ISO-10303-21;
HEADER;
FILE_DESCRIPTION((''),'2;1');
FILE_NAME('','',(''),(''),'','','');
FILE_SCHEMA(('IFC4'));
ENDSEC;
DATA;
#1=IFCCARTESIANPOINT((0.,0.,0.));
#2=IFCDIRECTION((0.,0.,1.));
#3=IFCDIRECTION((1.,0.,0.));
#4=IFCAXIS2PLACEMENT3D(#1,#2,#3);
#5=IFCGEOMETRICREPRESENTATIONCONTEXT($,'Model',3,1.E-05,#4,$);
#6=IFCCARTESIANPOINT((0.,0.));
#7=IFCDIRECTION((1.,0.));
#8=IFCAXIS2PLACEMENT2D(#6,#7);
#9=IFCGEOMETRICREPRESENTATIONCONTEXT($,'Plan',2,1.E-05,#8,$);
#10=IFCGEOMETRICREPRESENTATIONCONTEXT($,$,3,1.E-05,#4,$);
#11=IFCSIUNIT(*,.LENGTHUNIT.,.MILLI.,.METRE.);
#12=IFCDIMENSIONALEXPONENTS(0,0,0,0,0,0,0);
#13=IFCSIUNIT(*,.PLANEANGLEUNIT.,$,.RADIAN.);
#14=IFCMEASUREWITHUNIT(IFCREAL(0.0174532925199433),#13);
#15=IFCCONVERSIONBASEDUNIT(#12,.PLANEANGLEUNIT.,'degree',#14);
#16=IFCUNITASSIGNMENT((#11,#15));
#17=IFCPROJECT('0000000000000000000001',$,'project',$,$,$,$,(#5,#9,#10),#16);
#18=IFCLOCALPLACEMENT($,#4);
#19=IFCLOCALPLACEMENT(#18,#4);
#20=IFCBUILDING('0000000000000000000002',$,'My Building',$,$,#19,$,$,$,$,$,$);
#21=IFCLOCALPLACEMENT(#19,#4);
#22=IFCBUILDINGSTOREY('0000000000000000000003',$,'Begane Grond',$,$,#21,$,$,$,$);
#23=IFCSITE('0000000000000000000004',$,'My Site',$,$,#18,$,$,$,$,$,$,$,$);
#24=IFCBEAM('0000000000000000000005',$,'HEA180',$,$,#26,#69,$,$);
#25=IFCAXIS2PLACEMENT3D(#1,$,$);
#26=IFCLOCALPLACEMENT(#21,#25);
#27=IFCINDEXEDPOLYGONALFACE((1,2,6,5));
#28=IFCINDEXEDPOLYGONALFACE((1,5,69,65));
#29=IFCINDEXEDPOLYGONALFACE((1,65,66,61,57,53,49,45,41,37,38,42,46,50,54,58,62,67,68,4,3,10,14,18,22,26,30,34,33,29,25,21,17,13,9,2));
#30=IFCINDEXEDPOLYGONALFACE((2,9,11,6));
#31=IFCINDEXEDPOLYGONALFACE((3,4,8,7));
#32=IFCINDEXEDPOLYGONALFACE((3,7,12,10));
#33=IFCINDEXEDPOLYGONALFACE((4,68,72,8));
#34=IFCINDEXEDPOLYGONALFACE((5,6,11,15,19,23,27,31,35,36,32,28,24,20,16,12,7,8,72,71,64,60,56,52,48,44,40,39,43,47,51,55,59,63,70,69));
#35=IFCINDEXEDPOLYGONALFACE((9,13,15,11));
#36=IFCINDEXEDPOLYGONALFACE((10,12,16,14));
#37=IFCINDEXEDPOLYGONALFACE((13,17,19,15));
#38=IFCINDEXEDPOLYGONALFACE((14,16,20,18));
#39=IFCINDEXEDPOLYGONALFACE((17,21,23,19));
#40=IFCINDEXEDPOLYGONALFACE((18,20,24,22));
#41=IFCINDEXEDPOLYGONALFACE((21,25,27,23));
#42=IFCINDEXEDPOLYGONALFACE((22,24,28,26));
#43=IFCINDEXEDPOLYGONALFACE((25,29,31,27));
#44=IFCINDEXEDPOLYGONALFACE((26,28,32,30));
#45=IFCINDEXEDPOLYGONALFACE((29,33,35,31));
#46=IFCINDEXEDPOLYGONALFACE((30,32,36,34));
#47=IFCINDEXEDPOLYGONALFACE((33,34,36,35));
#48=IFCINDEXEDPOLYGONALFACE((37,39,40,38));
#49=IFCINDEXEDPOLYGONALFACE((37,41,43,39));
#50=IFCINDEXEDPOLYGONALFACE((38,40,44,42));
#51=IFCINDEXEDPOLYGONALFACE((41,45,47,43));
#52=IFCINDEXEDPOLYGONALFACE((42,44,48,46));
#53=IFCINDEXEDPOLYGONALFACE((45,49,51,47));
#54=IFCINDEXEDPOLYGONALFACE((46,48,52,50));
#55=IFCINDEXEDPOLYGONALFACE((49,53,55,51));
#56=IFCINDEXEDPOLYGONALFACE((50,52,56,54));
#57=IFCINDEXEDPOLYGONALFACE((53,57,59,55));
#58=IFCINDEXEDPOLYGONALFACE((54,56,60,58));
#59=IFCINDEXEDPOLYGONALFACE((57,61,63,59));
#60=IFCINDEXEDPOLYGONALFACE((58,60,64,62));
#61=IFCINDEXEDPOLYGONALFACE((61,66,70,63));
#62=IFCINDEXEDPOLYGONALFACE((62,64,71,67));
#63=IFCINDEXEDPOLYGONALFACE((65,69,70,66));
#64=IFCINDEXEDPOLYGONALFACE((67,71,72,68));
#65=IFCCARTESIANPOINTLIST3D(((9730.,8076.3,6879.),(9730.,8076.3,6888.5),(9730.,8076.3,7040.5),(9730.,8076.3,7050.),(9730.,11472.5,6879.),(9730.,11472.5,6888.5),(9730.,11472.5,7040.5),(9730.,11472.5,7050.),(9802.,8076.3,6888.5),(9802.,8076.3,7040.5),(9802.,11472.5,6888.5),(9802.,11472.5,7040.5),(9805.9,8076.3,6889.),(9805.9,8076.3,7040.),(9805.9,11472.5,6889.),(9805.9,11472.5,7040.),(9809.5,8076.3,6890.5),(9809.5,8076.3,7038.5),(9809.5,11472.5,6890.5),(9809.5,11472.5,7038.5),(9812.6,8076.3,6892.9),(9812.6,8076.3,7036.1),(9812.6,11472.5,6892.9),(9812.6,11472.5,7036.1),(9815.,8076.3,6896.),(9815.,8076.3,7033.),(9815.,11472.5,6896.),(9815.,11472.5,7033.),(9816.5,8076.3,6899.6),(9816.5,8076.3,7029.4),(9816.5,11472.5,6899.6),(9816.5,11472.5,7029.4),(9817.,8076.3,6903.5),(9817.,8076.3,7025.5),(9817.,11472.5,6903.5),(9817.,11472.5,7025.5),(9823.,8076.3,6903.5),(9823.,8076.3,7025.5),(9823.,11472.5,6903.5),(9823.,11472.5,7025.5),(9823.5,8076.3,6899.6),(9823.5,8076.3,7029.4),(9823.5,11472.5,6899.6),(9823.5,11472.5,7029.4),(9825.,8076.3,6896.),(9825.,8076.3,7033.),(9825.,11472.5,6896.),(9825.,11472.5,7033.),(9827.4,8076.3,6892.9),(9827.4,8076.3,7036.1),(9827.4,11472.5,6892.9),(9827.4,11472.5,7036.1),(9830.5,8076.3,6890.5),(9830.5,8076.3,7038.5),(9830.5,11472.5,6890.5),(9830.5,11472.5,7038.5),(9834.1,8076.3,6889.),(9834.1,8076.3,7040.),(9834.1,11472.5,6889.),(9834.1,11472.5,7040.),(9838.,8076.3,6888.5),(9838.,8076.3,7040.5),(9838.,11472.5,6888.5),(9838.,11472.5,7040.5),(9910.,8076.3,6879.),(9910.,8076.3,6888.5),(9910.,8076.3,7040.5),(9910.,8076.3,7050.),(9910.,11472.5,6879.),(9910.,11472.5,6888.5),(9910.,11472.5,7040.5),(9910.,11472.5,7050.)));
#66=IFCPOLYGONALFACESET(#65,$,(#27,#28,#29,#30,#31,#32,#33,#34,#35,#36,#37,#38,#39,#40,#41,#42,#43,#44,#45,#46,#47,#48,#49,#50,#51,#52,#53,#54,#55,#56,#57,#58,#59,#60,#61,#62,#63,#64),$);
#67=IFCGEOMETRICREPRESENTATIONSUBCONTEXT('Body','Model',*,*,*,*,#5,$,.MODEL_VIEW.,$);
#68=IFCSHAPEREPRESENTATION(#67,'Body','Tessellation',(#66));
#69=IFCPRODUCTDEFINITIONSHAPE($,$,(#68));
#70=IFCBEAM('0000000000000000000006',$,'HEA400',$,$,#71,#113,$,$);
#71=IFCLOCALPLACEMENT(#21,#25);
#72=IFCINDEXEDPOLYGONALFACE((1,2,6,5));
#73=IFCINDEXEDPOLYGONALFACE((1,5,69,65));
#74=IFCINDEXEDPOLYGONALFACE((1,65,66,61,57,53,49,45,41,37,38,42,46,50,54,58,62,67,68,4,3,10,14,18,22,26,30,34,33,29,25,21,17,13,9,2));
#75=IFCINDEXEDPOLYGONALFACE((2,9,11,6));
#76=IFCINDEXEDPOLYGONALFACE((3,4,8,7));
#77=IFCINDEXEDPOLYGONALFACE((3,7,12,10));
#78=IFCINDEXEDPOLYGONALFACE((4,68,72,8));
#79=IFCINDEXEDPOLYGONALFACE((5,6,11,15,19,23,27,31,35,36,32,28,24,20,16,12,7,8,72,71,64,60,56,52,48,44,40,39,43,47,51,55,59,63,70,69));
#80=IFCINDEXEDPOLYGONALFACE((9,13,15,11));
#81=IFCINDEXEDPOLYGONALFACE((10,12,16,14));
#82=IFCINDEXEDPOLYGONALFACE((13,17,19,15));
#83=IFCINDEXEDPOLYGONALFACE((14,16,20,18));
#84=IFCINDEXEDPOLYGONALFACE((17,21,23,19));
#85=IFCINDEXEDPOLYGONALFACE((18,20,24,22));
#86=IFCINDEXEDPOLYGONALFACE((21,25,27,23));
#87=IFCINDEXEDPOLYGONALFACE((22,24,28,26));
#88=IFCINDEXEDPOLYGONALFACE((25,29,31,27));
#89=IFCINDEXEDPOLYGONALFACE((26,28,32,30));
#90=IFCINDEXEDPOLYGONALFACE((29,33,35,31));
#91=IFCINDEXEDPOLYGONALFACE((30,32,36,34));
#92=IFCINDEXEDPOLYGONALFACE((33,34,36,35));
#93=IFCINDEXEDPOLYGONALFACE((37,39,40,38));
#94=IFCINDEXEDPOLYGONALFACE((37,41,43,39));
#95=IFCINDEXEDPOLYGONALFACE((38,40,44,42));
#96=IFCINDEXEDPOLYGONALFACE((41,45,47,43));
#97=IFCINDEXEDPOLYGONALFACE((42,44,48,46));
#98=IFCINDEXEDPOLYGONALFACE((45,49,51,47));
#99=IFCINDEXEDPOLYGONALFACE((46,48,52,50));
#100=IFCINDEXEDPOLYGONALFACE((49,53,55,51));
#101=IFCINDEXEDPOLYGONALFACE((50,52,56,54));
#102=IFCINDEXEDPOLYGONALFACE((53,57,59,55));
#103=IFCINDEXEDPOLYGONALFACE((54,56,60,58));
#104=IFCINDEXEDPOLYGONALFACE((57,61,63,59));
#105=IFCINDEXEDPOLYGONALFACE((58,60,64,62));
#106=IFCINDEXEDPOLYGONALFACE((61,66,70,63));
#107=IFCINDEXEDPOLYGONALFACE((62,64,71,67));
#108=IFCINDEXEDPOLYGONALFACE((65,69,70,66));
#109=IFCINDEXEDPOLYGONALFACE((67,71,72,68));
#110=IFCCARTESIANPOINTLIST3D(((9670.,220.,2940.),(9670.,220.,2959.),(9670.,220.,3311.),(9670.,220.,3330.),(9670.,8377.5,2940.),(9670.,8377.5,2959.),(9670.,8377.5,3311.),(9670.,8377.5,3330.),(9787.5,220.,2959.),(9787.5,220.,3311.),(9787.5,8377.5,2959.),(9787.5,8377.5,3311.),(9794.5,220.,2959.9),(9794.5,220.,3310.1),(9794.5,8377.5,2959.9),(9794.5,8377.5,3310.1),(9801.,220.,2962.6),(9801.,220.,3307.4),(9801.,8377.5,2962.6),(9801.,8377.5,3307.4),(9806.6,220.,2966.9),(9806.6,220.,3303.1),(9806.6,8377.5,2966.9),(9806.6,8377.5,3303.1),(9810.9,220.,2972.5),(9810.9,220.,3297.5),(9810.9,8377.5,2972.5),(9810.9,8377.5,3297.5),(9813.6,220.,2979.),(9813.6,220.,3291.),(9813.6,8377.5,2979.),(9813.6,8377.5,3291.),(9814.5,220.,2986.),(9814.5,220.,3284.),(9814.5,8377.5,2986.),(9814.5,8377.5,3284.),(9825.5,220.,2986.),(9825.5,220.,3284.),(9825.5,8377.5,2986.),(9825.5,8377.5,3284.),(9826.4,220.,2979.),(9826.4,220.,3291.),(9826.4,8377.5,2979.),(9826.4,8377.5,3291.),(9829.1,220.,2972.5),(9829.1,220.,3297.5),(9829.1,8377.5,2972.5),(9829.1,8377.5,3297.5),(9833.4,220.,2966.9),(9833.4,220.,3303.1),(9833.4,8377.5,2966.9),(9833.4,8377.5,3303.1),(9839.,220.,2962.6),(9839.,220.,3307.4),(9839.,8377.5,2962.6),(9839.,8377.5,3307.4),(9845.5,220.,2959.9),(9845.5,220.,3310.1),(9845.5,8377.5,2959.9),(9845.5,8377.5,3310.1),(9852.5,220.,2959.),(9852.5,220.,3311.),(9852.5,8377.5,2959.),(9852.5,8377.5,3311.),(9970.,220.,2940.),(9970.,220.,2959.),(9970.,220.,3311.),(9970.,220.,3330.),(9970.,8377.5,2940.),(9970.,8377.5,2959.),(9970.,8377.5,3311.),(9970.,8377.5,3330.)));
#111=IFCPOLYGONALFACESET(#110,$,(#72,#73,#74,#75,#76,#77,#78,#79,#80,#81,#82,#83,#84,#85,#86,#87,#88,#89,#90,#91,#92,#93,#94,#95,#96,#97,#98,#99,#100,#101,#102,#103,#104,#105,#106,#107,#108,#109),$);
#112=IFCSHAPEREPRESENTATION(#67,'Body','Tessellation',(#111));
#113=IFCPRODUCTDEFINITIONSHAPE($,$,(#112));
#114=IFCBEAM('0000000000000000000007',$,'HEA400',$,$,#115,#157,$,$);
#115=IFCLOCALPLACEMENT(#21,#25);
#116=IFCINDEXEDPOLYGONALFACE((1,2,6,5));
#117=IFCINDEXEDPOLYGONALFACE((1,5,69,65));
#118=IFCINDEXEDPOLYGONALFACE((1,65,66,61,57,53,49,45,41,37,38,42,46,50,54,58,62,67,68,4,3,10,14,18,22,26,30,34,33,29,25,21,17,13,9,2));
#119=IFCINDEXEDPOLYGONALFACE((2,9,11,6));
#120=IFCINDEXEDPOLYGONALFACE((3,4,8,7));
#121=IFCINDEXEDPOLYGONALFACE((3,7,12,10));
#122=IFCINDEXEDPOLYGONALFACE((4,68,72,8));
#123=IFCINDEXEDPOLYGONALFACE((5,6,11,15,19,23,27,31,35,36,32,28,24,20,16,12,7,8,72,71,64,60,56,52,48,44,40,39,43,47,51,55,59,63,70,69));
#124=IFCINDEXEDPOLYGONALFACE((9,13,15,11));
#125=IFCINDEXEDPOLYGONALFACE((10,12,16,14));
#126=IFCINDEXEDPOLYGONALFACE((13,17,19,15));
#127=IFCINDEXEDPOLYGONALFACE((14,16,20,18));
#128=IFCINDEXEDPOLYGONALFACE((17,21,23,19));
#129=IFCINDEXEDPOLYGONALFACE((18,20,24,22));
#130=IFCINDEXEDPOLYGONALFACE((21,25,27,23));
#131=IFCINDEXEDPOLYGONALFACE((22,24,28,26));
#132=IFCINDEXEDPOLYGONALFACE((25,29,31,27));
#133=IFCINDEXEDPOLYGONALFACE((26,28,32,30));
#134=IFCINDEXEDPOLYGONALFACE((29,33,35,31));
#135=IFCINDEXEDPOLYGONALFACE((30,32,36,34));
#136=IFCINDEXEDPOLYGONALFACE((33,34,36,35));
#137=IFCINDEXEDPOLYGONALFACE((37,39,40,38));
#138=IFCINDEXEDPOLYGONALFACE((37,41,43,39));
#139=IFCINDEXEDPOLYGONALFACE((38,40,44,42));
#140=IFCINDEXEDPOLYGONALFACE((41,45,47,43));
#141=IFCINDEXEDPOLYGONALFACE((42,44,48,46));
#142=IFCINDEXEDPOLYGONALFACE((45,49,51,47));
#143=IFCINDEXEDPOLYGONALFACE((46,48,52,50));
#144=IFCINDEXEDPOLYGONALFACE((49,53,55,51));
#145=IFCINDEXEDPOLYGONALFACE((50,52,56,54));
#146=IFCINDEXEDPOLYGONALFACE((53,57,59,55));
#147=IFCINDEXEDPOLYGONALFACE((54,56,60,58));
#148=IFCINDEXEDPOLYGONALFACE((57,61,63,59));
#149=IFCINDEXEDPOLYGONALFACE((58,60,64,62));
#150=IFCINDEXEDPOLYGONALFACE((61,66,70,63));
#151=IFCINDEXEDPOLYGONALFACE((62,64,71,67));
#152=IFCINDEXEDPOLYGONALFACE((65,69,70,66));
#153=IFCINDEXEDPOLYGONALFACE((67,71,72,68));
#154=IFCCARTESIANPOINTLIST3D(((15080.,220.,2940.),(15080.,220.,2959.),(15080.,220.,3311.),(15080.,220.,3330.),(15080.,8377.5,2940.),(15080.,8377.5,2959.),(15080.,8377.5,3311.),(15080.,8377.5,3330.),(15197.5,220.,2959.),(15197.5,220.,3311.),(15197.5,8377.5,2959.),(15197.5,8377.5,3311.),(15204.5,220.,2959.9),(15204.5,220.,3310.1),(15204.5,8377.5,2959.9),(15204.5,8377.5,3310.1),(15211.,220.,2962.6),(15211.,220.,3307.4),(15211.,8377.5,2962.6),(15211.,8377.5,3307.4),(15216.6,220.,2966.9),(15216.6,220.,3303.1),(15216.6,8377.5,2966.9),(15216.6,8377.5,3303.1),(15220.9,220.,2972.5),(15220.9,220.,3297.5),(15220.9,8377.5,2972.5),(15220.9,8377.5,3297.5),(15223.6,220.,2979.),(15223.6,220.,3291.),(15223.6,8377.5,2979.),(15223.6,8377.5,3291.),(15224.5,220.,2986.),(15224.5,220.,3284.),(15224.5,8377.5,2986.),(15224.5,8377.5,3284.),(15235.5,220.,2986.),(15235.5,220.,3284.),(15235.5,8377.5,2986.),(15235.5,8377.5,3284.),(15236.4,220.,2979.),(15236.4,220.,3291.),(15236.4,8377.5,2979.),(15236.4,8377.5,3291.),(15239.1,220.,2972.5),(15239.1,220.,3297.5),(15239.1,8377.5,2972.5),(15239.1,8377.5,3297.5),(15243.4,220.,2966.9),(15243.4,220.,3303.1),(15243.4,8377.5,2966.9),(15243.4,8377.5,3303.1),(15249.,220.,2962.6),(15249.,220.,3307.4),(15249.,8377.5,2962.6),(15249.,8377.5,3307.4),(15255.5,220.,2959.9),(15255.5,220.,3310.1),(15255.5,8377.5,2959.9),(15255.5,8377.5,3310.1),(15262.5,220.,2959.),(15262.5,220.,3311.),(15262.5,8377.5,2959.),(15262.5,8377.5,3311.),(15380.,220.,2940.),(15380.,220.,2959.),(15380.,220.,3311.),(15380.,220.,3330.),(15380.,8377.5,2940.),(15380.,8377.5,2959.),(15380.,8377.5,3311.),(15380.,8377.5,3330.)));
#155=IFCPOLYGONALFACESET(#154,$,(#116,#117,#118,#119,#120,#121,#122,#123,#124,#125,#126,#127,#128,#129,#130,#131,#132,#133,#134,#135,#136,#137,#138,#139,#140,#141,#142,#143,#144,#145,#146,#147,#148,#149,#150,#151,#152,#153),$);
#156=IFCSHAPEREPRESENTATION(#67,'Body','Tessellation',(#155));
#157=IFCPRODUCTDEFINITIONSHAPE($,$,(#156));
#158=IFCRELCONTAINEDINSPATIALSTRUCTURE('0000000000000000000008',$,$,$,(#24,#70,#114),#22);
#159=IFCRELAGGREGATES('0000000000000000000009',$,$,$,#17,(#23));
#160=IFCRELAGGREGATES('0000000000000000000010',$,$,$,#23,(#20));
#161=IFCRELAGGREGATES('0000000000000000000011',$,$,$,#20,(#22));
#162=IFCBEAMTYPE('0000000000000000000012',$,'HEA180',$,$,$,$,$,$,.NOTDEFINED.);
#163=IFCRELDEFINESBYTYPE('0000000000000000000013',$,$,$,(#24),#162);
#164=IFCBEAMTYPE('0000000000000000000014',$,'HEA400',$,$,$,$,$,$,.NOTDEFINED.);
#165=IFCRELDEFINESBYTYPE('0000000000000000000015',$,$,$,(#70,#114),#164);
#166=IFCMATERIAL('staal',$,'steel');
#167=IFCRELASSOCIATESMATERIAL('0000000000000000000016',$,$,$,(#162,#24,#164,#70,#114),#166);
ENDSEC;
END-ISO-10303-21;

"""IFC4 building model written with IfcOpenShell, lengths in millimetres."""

from ifc_helpers import new_model, entity, si_unit, converted_unit, frame, origin_with_axes, origin_2d_with_axis, place, context, subcontext, project, spatial, i_section, extrude, material, material_profile, profile_set, profile_usage, type_object, element, save


model = new_model("IFC4")

# Units and contexts
model_context = context("Model", 3, precision=1e-05, world=origin_with_axes())
plan_context = context("Plan", 2, precision=1e-05, world=origin_2d_with_axis())
context_of_model = context(None, 3, precision=1e-05, world=origin_with_axes())
body_context = subcontext(model_context, "Body", "Model", "MODEL_VIEW")
ifc_project = project(units=[si_unit("LENGTHUNIT", "METRE", prefix="MILLI"), converted_unit("PLANEANGLEUNIT", "degree", entity("IfcReal", 0.0174532925199433), si_unit("PLANEANGLEUNIT", "RADIAN"), dimensions=[0, 0, 0, 0, 0, 0, 0])], contexts=[model_context, plan_context, context_of_model])

# Site, building, storey
site_placement = place(None, origin_with_axes())
site = spatial("IfcSite", under=ifc_project, at=site_placement, Name="My Site")
building_placement = place(site_placement, origin_with_axes())
building = spatial("IfcBuilding", under=site, at=building_placement, Name="My Building")
storey_placement = place(building_placement, origin_with_axes())
storey = spatial("IfcBuildingStorey", under=building, at=storey_placement, Name="Begane Grond")

# Shared definitions
ifc_material = material(Name="staal", Category="steel")

# Beams
ifc_material_profile_1 = material_profile(ifc_material, i_section(OverallWidth=180.0, OverallDepth=171.0, WebThickness=6.0, FlangeThickness=9.5, FilletRadius=15.0))
ifc_profile_set_1 = profile_set([ifc_material_profile_1], Name="HEA180")
beam_type_1 = type_object("IfcBeamType", Name="HEA180", PredefinedType="NOTDEFINED", material=ifc_profile_set_1)
ifc_profile_usage_1 = profile_usage(ifc_profile_set_1)
beam_1_placement = place(storey_placement, frame((9820.0, 11472.5, 6964.5), z_axis=(0.0, -1.0, 0.0), x_axis=(1.0, 0.0, 0.0)))
element("IfcBeam", 1, at=beam_1_placement, inside=storey, type_object=beam_type_1, material=ifc_profile_usage_1, Name="HEA180", context=body_context, shape_type="SweptSolid", body=[
    extrude(i_section(OverallWidth=180.0, OverallDepth=171.0, WebThickness=6.0, FlangeThickness=9.5, FilletRadius=15.0), origin_with_axes(), (0.0, 0.0, 1.0), 3396.2),
])
ifc_material_profile_2 = material_profile(ifc_material, i_section(OverallWidth=300.0, OverallDepth=390.0, WebThickness=11.0, FlangeThickness=19.0, FilletRadius=27.0))
ifc_profile_set_2 = profile_set([ifc_material_profile_2], Name="HEA400")
ifc_profile_usage_2 = profile_usage(ifc_profile_set_2, cardinal=5)
beam_type_2 = type_object("IfcBeamType", Name="HEA400", PredefinedType="NOTDEFINED", material=ifc_profile_set_2)
beam_2_placement = place(storey_placement, frame((9820.0, 220.0, 3135.0), z_axis=(0.0, 1.0, 0.0), x_axis=(-1.0, 0.0, 0.0)))
element("IfcBeam", 2, at=beam_2_placement, inside=storey, type_object=beam_type_2, material=ifc_profile_usage_2, Name="HEA400", context=body_context, shape_type="SweptSolid", body=[
    extrude(i_section(OverallWidth=300.0, OverallDepth=390.0, WebThickness=11.0, FlangeThickness=19.0, FilletRadius=27.0), origin_with_axes(), (0.0, 0.0, 1.0), 8157.5),
])
ifc_profile_usage_3 = profile_usage(ifc_profile_set_2, cardinal=5)
beam_3_placement = place(storey_placement, frame((15230.0, 220.0, 3135.0), z_axis=(0.0, 1.0, 0.0), x_axis=(-1.0, 0.0, 0.0)))
element("IfcBeam", 3, at=beam_3_placement, inside=storey, type_object=beam_type_2, material=ifc_profile_usage_3, Name="HEA400", context=body_context, shape_type="SweptSolid", body=[
    extrude(i_section(OverallWidth=300.0, OverallDepth=390.0, WebThickness=11.0, FlangeThickness=19.0, FilletRadius=27.0), origin_with_axes(), (0.0, 0.0, 1.0), 8157.5),
])

save(model, "model.ifc")
